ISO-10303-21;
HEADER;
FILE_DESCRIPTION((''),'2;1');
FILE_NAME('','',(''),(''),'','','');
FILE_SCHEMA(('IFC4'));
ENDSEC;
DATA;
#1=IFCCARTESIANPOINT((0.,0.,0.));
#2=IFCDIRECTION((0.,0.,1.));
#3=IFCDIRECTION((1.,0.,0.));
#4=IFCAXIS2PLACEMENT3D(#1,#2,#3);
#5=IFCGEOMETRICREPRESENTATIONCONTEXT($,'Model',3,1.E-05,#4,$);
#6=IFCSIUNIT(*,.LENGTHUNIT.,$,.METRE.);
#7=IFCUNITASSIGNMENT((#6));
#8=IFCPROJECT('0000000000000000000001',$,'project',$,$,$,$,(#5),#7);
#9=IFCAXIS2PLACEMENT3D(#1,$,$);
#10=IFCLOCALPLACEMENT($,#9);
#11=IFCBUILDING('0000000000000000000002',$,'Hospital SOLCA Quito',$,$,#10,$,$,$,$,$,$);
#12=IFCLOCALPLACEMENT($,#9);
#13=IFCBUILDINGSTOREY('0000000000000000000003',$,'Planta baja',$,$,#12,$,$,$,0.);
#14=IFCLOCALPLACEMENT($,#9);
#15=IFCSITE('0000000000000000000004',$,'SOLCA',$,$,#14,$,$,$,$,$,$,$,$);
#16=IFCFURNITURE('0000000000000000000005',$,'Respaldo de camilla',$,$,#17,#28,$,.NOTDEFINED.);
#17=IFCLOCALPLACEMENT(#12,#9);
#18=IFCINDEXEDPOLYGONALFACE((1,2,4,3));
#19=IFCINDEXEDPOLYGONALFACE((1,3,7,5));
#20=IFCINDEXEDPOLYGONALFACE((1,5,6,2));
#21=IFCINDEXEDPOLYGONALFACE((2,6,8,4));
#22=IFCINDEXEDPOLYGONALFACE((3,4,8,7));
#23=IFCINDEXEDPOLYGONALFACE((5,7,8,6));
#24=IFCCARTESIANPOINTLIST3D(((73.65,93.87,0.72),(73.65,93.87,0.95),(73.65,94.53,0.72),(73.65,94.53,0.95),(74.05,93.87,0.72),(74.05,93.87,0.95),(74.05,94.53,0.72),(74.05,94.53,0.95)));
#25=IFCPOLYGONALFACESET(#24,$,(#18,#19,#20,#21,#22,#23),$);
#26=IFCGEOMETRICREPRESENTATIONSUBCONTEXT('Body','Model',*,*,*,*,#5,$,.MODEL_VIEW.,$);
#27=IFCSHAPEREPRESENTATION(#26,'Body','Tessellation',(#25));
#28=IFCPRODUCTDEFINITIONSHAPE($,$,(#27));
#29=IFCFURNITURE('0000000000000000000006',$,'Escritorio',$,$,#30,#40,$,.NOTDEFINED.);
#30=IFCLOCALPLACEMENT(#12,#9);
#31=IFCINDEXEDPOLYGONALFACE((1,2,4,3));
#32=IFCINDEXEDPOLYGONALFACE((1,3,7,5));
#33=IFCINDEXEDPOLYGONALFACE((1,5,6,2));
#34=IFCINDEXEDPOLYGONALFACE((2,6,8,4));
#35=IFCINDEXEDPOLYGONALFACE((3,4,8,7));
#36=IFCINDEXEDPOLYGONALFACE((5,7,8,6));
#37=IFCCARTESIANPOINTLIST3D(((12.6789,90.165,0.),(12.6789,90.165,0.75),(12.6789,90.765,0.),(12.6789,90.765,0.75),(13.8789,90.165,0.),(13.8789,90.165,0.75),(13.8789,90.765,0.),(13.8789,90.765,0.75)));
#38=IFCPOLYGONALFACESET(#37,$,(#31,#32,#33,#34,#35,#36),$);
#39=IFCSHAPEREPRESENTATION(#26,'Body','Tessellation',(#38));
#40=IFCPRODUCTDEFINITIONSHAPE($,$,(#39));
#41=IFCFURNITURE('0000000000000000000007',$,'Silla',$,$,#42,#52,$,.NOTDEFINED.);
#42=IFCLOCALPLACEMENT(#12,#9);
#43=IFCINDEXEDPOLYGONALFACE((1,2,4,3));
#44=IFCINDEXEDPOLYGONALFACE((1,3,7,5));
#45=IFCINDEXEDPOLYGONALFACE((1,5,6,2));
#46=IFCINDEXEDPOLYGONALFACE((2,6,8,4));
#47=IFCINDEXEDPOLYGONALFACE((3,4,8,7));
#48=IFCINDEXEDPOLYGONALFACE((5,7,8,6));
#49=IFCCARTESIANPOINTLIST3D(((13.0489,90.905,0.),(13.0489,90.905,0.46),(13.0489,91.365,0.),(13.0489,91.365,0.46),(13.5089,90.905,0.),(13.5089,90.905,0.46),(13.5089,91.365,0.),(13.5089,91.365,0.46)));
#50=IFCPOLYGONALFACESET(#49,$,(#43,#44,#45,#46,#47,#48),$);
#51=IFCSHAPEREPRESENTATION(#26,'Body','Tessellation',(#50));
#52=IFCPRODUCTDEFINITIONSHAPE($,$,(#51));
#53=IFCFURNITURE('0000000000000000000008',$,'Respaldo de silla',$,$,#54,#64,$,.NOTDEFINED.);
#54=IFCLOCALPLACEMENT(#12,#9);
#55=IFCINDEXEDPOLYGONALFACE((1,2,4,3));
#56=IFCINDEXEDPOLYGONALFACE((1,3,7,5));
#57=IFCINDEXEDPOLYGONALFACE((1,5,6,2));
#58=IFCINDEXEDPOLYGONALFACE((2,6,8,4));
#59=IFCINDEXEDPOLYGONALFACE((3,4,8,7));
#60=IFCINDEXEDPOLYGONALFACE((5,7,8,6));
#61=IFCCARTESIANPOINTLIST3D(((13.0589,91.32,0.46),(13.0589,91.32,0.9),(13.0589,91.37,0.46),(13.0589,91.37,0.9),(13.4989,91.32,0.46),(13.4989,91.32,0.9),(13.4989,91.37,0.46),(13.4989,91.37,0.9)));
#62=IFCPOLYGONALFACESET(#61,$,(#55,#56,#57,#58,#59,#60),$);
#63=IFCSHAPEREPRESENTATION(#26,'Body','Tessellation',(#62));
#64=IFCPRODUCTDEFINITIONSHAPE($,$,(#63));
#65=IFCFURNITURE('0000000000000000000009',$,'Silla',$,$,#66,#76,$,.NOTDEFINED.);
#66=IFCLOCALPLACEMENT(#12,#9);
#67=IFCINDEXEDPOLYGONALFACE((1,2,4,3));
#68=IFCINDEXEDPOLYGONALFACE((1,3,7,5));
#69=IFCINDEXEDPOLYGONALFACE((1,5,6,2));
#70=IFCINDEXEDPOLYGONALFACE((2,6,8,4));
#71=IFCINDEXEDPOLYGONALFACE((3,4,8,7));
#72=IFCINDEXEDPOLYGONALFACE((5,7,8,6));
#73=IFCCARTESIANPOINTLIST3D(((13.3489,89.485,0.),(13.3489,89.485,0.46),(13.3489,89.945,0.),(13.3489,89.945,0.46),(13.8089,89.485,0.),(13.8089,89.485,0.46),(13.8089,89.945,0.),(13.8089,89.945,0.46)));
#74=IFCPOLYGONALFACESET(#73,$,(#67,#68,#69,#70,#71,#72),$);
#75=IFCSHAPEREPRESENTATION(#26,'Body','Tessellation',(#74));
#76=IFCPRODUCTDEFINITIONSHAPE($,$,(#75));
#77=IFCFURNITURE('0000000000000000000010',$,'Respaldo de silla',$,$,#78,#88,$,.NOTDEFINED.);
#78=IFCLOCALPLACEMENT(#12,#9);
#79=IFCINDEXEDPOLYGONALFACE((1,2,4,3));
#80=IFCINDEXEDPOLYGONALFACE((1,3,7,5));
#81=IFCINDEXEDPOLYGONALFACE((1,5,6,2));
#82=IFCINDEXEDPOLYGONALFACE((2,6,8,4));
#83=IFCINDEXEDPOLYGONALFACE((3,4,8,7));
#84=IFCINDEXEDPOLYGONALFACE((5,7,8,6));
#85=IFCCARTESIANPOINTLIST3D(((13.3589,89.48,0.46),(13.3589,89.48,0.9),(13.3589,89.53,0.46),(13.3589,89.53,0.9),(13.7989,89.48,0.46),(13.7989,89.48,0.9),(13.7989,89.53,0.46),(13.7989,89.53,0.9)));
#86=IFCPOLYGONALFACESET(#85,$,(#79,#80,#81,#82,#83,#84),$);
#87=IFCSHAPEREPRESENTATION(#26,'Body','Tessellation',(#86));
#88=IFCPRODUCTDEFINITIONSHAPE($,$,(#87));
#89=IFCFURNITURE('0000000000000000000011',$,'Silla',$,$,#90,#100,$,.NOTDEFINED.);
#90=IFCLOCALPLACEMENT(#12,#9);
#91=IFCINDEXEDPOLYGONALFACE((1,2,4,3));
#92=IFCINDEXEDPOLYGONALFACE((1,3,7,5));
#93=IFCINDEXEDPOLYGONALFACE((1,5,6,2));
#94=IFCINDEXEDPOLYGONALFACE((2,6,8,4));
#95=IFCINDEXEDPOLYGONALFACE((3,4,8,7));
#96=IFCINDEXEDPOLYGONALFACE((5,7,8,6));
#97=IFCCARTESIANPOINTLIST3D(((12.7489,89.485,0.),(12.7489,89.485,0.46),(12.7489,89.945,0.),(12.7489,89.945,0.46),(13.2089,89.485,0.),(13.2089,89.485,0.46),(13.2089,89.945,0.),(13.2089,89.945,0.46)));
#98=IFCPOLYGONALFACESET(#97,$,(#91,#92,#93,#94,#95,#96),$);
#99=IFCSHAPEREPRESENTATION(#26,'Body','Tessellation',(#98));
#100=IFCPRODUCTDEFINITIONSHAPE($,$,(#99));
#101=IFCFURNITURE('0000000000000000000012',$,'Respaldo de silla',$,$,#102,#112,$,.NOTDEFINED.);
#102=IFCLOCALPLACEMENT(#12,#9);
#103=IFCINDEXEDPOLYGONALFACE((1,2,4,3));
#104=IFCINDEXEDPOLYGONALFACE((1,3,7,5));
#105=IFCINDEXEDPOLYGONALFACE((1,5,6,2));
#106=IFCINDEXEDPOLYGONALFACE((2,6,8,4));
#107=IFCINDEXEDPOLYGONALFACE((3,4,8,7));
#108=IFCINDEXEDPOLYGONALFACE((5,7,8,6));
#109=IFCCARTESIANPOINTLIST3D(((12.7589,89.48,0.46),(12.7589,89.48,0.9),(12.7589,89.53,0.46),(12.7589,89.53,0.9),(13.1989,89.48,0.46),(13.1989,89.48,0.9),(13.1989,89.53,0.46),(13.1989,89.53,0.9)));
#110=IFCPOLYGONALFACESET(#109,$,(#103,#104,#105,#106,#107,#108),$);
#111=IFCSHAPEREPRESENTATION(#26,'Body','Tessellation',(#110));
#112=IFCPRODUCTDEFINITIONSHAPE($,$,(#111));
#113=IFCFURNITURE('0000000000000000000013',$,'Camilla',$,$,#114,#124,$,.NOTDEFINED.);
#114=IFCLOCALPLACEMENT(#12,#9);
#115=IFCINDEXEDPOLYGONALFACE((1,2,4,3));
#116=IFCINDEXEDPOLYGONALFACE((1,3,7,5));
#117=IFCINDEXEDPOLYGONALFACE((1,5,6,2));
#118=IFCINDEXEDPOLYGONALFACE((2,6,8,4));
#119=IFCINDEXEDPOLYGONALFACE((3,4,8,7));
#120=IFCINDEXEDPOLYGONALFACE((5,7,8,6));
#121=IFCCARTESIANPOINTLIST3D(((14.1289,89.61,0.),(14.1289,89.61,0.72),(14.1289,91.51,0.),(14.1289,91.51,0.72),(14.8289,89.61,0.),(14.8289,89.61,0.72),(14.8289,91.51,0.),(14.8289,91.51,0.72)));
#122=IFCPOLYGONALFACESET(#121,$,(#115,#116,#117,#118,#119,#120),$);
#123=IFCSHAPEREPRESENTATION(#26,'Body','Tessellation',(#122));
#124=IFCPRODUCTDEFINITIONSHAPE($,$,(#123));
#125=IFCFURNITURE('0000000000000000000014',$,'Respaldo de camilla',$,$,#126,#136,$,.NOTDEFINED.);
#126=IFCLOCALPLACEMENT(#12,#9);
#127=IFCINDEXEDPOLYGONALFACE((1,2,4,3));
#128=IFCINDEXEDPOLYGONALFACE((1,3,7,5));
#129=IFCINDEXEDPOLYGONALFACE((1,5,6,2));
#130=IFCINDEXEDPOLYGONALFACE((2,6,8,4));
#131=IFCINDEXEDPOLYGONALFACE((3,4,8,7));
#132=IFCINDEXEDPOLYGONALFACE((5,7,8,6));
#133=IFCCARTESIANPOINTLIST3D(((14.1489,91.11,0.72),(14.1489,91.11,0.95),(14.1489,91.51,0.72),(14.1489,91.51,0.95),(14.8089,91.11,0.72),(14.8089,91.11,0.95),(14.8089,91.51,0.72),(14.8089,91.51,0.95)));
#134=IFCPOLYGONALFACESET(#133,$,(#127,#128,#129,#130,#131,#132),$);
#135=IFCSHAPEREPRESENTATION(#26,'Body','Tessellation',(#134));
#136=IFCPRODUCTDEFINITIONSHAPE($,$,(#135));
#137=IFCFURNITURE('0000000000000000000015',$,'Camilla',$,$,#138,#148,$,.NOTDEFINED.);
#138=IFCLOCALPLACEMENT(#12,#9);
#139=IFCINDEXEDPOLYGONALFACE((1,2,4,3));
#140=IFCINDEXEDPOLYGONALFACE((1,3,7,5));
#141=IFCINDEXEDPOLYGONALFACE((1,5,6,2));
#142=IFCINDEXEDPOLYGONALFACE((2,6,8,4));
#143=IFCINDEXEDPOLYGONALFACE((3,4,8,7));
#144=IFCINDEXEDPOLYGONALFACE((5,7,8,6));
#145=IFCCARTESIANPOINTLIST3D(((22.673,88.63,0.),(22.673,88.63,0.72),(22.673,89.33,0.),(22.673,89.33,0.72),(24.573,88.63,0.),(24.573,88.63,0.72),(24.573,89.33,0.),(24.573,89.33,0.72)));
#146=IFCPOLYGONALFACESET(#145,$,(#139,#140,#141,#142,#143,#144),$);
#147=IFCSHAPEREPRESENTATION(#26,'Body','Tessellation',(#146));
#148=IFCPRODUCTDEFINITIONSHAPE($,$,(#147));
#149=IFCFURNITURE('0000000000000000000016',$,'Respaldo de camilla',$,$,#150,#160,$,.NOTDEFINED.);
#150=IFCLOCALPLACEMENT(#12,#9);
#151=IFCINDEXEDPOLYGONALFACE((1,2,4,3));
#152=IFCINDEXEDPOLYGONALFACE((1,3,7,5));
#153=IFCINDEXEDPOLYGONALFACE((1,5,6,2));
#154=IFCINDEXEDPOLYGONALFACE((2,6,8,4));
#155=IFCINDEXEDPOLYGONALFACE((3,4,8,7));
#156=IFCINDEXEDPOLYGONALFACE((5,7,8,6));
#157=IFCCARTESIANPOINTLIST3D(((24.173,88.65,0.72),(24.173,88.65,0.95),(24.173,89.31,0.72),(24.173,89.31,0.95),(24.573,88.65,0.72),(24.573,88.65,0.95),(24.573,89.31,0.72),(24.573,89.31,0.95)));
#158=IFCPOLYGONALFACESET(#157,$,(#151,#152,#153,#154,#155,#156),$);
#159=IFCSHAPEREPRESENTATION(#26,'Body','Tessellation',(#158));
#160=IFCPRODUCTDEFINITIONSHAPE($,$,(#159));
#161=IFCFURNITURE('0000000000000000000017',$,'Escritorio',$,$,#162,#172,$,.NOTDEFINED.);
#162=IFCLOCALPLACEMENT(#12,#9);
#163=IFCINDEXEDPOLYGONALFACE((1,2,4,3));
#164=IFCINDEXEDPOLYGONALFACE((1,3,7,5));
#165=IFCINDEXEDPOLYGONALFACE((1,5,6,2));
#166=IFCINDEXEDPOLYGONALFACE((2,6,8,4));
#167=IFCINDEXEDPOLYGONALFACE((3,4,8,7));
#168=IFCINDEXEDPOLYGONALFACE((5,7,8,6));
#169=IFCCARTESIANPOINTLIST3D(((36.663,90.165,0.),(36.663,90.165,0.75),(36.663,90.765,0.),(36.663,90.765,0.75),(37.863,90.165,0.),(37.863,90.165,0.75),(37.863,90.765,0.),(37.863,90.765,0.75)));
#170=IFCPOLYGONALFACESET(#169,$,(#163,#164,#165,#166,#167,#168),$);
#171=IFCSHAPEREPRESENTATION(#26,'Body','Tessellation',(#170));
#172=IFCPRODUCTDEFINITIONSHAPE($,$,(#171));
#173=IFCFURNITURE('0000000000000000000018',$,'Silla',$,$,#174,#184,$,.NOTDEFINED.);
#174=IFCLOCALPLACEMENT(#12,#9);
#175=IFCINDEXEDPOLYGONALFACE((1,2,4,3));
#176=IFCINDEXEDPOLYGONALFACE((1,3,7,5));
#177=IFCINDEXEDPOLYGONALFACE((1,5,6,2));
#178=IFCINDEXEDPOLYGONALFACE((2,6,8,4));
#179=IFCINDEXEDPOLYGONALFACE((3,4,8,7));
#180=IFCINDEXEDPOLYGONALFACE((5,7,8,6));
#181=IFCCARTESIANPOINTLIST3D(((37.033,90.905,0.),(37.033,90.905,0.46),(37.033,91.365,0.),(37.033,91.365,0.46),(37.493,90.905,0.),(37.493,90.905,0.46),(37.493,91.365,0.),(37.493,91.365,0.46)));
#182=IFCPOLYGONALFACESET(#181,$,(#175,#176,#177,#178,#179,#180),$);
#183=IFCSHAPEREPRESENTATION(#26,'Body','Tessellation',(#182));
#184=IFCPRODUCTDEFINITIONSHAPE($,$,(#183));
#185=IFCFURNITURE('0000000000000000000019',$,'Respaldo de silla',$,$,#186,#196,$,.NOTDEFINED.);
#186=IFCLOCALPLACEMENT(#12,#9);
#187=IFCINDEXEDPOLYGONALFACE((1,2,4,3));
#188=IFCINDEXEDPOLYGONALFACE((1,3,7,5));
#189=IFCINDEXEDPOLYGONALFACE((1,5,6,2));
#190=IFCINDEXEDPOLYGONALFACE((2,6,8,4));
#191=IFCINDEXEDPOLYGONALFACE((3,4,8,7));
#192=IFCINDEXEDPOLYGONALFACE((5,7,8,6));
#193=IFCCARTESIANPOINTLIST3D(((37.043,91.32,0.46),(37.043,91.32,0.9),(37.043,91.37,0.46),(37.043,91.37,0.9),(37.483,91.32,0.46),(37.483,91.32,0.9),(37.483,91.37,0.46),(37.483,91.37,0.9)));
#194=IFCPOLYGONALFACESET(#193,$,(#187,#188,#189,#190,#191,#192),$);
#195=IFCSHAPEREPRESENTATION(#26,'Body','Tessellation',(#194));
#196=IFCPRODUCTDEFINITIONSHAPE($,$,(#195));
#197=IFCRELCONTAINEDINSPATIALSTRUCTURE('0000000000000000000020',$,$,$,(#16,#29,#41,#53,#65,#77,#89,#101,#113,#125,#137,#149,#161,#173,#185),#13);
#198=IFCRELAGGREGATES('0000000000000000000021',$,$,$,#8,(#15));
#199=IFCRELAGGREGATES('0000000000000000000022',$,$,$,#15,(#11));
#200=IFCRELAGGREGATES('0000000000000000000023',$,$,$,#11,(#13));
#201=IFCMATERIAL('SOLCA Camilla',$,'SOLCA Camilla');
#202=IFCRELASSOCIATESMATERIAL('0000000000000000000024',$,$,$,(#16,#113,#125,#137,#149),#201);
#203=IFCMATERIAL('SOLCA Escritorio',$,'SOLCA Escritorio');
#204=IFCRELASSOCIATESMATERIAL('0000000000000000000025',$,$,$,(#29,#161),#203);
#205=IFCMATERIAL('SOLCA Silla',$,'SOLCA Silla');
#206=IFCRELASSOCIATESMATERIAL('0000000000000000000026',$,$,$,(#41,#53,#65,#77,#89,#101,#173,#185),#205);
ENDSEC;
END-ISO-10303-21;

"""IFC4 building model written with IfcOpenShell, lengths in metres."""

from ifc_helpers import new_model, si_unit, frame, origin, origin_with_axes, place, context, subcontext, project, spatial, polyline, outline, extrude, material, element, save


model = new_model("IFC4")

# Units and contexts
model_context = context("Model", 3, precision=1e-05, world=origin_with_axes())
body_context = subcontext(model_context, "Body", "Model", "MODEL_VIEW")
ifc_project = project(units=[si_unit("LENGTHUNIT", "METRE")], contexts=[model_context])

# Site, building, storey
site_placement = place(None, origin())
site = spatial("IfcSite", under=ifc_project, at=site_placement, Name="SOLCA")
building_placement = place(None, origin())
building = spatial("IfcBuilding", under=site, at=building_placement, Name="Hospital SOLCA Quito")
storey_placement = place(None, origin())
storey = spatial("IfcBuildingStorey", under=building, at=storey_placement, Name="Planta baja", Elevation=0.0)

# Furniture
ifc_material_1 = material(Name="SOLCA Silla", Category="SOLCA Silla")
ifc_material_2 = material(Name="SOLCA Camilla", Category="SOLCA Camilla")
ifc_material_3 = material(Name="SOLCA Escritorio", Category="SOLCA Escritorio")
furniture_1_placement = place(storey_placement, origin_with_axes())
element("IfcFurniture", 1, at=furniture_1_placement, inside=storey, material=ifc_material_2, Name="Respaldo de camilla", PredefinedType="NOTDEFINED", context=body_context, shape_type="SweptSolid", body=[
    extrude(outline(polyline([(74.05, 94.53), (73.65, 94.53), (73.65, 93.87), (74.05, 93.87), (74.05, 94.53)])), frame((0.0, 0.0, 0.72), z_axis=(0.0, 0.0, 1.0), x_axis=(1.0, 0.0, 0.0)), (0.0, 0.0, 1.0), 0.23),
])
furniture_2_placement = place(storey_placement, origin_with_axes())
element("IfcFurniture", 2, at=furniture_2_placement, inside=storey, material=ifc_material_3, Name="Escritorio", PredefinedType="NOTDEFINED", context=body_context, shape_type="SweptSolid", body=[
    extrude(outline(polyline([(13.8789, 90.765), (12.6789, 90.765), (12.6789, 90.165), (13.8789, 90.165), (13.8789, 90.765)])), origin_with_axes(), (0.0, 0.0, 1.0), 0.75),
])
furniture_3_placement = place(storey_placement, origin_with_axes())
element("IfcFurniture", 3, at=furniture_3_placement, inside=storey, material=ifc_material_1, Name="Silla", PredefinedType="NOTDEFINED", context=body_context, shape_type="SweptSolid", body=[
    extrude(outline(polyline([(13.5089, 91.365), (13.0489, 91.365), (13.0489, 90.905), (13.5089, 90.905), (13.5089, 91.365)])), origin_with_axes(), (0.0, 0.0, 1.0), 0.46),
])
furniture_4_placement = place(storey_placement, origin_with_axes())
element("IfcFurniture", 4, at=furniture_4_placement, inside=storey, material=ifc_material_1, Name="Respaldo de silla", PredefinedType="NOTDEFINED", context=body_context, shape_type="SweptSolid", body=[
    extrude(outline(polyline([(13.4989, 91.37), (13.0589, 91.37), (13.0589, 91.32), (13.4989, 91.32), (13.4989, 91.37)])), frame((0.0, 0.0, 0.46), z_axis=(0.0, 0.0, 1.0), x_axis=(1.0, 0.0, 0.0)), (0.0, 0.0, 1.0), 0.44),
])
furniture_5_placement = place(storey_placement, origin_with_axes())
element("IfcFurniture", 5, at=furniture_5_placement, inside=storey, material=ifc_material_1, Name="Silla", PredefinedType="NOTDEFINED", context=body_context, shape_type="SweptSolid", body=[
    extrude(outline(polyline([(13.8089, 89.945), (13.3489, 89.945), (13.3489, 89.485), (13.8089, 89.485), (13.8089, 89.945)])), origin_with_axes(), (0.0, 0.0, 1.0), 0.46),
])
furniture_6_placement = place(storey_placement, origin_with_axes())
element("IfcFurniture", 6, at=furniture_6_placement, inside=storey, material=ifc_material_1, Name="Respaldo de silla", PredefinedType="NOTDEFINED", context=body_context, shape_type="SweptSolid", body=[
    extrude(outline(polyline([(13.7989, 89.53), (13.3589, 89.53), (13.3589, 89.48), (13.7989, 89.48), (13.7989, 89.53)])), frame((0.0, 0.0, 0.46), z_axis=(0.0, 0.0, 1.0), x_axis=(1.0, 0.0, 0.0)), (0.0, 0.0, 1.0), 0.44),
])
furniture_7_placement = place(storey_placement, origin_with_axes())
element("IfcFurniture", 7, at=furniture_7_placement, inside=storey, material=ifc_material_1, Name="Silla", PredefinedType="NOTDEFINED", context=body_context, shape_type="SweptSolid", body=[
    extrude(outline(polyline([(13.2089, 89.945), (12.7489, 89.945), (12.7489, 89.485), (13.2089, 89.485), (13.2089, 89.945)])), origin_with_axes(), (0.0, 0.0, 1.0), 0.46),
])
furniture_8_placement = place(storey_placement, origin_with_axes())
element("IfcFurniture", 8, at=furniture_8_placement, inside=storey, material=ifc_material_1, Name="Respaldo de silla", PredefinedType="NOTDEFINED", context=body_context, shape_type="SweptSolid", body=[
    extrude(outline(polyline([(13.1989, 89.53), (12.7589, 89.53), (12.7589, 89.48), (13.1989, 89.48), (13.1989, 89.53)])), frame((0.0, 0.0, 0.46), z_axis=(0.0, 0.0, 1.0), x_axis=(1.0, 0.0, 0.0)), (0.0, 0.0, 1.0), 0.44),
])
furniture_9_placement = place(storey_placement, origin_with_axes())
element("IfcFurniture", 9, at=furniture_9_placement, inside=storey, material=ifc_material_2, Name="Camilla", PredefinedType="NOTDEFINED", context=body_context, shape_type="SweptSolid", body=[
    extrude(outline(polyline([(14.8289, 89.61), (14.8289, 91.51), (14.1289, 91.51), (14.1289, 89.61), (14.8289, 89.61)])), origin_with_axes(), (0.0, 0.0, 1.0), 0.72),
])
furniture_10_placement = place(storey_placement, origin_with_axes())
element("IfcFurniture", 10, at=furniture_10_placement, inside=storey, material=ifc_material_2, Name="Respaldo de camilla", PredefinedType="NOTDEFINED", context=body_context, shape_type="SweptSolid", body=[
    extrude(outline(polyline([(14.8089, 91.11), (14.8089, 91.51), (14.1489, 91.51), (14.1489, 91.11), (14.8089, 91.11)])), frame((0.0, 0.0, 0.72), z_axis=(0.0, 0.0, 1.0), x_axis=(1.0, 0.0, 0.0)), (0.0, 0.0, 1.0), 0.23),
])
furniture_11_placement = place(storey_placement, origin_with_axes())
element("IfcFurniture", 11, at=furniture_11_placement, inside=storey, material=ifc_material_2, Name="Camilla", PredefinedType="NOTDEFINED", context=body_context, shape_type="SweptSolid", body=[
    extrude(outline(polyline([(22.673, 88.63), (24.573, 88.63), (24.573, 89.33), (22.673, 89.33), (22.673, 88.63)])), origin_with_axes(), (0.0, 0.0, 1.0), 0.72),
])
furniture_12_placement = place(storey_placement, origin_with_axes())
element("IfcFurniture", 12, at=furniture_12_placement, inside=storey, material=ifc_material_2, Name="Respaldo de camilla", PredefinedType="NOTDEFINED", context=body_context, shape_type="SweptSolid", body=[
    extrude(outline(polyline([(24.173, 88.65), (24.573, 88.65), (24.573, 89.31), (24.173, 89.31), (24.173, 88.65)])), frame((0.0, 0.0, 0.72), z_axis=(0.0, 0.0, 1.0), x_axis=(1.0, 0.0, 0.0)), (0.0, 0.0, 1.0), 0.23),
])
furniture_13_placement = place(storey_placement, origin_with_axes())
element("IfcFurniture", 13, at=furniture_13_placement, inside=storey, material=ifc_material_3, Name="Escritorio", PredefinedType="NOTDEFINED", context=body_context, shape_type="SweptSolid", body=[
    extrude(outline(polyline([(37.863, 90.765), (36.663, 90.765), (36.663, 90.165), (37.863, 90.165), (37.863, 90.765)])), origin_with_axes(), (0.0, 0.0, 1.0), 0.75),
])
furniture_14_placement = place(storey_placement, origin_with_axes())
element("IfcFurniture", 14, at=furniture_14_placement, inside=storey, material=ifc_material_1, Name="Silla", PredefinedType="NOTDEFINED", context=body_context, shape_type="SweptSolid", body=[
    extrude(outline(polyline([(37.493, 91.365), (37.033, 91.365), (37.033, 90.905), (37.493, 90.905), (37.493, 91.365)])), origin_with_axes(), (0.0, 0.0, 1.0), 0.46),
])
furniture_15_placement = place(storey_placement, origin_with_axes())
element("IfcFurniture", 15, at=furniture_15_placement, inside=storey, material=ifc_material_1, Name="Respaldo de silla", PredefinedType="NOTDEFINED", context=body_context, shape_type="SweptSolid", body=[
    extrude(outline(polyline([(37.483, 91.37), (37.043, 91.37), (37.043, 91.32), (37.483, 91.32), (37.483, 91.37)])), frame((0.0, 0.0, 0.46), z_axis=(0.0, 0.0, 1.0), x_axis=(1.0, 0.0, 0.0)), (0.0, 0.0, 1.0), 0.44),
])

save(model, "model.ifc")
